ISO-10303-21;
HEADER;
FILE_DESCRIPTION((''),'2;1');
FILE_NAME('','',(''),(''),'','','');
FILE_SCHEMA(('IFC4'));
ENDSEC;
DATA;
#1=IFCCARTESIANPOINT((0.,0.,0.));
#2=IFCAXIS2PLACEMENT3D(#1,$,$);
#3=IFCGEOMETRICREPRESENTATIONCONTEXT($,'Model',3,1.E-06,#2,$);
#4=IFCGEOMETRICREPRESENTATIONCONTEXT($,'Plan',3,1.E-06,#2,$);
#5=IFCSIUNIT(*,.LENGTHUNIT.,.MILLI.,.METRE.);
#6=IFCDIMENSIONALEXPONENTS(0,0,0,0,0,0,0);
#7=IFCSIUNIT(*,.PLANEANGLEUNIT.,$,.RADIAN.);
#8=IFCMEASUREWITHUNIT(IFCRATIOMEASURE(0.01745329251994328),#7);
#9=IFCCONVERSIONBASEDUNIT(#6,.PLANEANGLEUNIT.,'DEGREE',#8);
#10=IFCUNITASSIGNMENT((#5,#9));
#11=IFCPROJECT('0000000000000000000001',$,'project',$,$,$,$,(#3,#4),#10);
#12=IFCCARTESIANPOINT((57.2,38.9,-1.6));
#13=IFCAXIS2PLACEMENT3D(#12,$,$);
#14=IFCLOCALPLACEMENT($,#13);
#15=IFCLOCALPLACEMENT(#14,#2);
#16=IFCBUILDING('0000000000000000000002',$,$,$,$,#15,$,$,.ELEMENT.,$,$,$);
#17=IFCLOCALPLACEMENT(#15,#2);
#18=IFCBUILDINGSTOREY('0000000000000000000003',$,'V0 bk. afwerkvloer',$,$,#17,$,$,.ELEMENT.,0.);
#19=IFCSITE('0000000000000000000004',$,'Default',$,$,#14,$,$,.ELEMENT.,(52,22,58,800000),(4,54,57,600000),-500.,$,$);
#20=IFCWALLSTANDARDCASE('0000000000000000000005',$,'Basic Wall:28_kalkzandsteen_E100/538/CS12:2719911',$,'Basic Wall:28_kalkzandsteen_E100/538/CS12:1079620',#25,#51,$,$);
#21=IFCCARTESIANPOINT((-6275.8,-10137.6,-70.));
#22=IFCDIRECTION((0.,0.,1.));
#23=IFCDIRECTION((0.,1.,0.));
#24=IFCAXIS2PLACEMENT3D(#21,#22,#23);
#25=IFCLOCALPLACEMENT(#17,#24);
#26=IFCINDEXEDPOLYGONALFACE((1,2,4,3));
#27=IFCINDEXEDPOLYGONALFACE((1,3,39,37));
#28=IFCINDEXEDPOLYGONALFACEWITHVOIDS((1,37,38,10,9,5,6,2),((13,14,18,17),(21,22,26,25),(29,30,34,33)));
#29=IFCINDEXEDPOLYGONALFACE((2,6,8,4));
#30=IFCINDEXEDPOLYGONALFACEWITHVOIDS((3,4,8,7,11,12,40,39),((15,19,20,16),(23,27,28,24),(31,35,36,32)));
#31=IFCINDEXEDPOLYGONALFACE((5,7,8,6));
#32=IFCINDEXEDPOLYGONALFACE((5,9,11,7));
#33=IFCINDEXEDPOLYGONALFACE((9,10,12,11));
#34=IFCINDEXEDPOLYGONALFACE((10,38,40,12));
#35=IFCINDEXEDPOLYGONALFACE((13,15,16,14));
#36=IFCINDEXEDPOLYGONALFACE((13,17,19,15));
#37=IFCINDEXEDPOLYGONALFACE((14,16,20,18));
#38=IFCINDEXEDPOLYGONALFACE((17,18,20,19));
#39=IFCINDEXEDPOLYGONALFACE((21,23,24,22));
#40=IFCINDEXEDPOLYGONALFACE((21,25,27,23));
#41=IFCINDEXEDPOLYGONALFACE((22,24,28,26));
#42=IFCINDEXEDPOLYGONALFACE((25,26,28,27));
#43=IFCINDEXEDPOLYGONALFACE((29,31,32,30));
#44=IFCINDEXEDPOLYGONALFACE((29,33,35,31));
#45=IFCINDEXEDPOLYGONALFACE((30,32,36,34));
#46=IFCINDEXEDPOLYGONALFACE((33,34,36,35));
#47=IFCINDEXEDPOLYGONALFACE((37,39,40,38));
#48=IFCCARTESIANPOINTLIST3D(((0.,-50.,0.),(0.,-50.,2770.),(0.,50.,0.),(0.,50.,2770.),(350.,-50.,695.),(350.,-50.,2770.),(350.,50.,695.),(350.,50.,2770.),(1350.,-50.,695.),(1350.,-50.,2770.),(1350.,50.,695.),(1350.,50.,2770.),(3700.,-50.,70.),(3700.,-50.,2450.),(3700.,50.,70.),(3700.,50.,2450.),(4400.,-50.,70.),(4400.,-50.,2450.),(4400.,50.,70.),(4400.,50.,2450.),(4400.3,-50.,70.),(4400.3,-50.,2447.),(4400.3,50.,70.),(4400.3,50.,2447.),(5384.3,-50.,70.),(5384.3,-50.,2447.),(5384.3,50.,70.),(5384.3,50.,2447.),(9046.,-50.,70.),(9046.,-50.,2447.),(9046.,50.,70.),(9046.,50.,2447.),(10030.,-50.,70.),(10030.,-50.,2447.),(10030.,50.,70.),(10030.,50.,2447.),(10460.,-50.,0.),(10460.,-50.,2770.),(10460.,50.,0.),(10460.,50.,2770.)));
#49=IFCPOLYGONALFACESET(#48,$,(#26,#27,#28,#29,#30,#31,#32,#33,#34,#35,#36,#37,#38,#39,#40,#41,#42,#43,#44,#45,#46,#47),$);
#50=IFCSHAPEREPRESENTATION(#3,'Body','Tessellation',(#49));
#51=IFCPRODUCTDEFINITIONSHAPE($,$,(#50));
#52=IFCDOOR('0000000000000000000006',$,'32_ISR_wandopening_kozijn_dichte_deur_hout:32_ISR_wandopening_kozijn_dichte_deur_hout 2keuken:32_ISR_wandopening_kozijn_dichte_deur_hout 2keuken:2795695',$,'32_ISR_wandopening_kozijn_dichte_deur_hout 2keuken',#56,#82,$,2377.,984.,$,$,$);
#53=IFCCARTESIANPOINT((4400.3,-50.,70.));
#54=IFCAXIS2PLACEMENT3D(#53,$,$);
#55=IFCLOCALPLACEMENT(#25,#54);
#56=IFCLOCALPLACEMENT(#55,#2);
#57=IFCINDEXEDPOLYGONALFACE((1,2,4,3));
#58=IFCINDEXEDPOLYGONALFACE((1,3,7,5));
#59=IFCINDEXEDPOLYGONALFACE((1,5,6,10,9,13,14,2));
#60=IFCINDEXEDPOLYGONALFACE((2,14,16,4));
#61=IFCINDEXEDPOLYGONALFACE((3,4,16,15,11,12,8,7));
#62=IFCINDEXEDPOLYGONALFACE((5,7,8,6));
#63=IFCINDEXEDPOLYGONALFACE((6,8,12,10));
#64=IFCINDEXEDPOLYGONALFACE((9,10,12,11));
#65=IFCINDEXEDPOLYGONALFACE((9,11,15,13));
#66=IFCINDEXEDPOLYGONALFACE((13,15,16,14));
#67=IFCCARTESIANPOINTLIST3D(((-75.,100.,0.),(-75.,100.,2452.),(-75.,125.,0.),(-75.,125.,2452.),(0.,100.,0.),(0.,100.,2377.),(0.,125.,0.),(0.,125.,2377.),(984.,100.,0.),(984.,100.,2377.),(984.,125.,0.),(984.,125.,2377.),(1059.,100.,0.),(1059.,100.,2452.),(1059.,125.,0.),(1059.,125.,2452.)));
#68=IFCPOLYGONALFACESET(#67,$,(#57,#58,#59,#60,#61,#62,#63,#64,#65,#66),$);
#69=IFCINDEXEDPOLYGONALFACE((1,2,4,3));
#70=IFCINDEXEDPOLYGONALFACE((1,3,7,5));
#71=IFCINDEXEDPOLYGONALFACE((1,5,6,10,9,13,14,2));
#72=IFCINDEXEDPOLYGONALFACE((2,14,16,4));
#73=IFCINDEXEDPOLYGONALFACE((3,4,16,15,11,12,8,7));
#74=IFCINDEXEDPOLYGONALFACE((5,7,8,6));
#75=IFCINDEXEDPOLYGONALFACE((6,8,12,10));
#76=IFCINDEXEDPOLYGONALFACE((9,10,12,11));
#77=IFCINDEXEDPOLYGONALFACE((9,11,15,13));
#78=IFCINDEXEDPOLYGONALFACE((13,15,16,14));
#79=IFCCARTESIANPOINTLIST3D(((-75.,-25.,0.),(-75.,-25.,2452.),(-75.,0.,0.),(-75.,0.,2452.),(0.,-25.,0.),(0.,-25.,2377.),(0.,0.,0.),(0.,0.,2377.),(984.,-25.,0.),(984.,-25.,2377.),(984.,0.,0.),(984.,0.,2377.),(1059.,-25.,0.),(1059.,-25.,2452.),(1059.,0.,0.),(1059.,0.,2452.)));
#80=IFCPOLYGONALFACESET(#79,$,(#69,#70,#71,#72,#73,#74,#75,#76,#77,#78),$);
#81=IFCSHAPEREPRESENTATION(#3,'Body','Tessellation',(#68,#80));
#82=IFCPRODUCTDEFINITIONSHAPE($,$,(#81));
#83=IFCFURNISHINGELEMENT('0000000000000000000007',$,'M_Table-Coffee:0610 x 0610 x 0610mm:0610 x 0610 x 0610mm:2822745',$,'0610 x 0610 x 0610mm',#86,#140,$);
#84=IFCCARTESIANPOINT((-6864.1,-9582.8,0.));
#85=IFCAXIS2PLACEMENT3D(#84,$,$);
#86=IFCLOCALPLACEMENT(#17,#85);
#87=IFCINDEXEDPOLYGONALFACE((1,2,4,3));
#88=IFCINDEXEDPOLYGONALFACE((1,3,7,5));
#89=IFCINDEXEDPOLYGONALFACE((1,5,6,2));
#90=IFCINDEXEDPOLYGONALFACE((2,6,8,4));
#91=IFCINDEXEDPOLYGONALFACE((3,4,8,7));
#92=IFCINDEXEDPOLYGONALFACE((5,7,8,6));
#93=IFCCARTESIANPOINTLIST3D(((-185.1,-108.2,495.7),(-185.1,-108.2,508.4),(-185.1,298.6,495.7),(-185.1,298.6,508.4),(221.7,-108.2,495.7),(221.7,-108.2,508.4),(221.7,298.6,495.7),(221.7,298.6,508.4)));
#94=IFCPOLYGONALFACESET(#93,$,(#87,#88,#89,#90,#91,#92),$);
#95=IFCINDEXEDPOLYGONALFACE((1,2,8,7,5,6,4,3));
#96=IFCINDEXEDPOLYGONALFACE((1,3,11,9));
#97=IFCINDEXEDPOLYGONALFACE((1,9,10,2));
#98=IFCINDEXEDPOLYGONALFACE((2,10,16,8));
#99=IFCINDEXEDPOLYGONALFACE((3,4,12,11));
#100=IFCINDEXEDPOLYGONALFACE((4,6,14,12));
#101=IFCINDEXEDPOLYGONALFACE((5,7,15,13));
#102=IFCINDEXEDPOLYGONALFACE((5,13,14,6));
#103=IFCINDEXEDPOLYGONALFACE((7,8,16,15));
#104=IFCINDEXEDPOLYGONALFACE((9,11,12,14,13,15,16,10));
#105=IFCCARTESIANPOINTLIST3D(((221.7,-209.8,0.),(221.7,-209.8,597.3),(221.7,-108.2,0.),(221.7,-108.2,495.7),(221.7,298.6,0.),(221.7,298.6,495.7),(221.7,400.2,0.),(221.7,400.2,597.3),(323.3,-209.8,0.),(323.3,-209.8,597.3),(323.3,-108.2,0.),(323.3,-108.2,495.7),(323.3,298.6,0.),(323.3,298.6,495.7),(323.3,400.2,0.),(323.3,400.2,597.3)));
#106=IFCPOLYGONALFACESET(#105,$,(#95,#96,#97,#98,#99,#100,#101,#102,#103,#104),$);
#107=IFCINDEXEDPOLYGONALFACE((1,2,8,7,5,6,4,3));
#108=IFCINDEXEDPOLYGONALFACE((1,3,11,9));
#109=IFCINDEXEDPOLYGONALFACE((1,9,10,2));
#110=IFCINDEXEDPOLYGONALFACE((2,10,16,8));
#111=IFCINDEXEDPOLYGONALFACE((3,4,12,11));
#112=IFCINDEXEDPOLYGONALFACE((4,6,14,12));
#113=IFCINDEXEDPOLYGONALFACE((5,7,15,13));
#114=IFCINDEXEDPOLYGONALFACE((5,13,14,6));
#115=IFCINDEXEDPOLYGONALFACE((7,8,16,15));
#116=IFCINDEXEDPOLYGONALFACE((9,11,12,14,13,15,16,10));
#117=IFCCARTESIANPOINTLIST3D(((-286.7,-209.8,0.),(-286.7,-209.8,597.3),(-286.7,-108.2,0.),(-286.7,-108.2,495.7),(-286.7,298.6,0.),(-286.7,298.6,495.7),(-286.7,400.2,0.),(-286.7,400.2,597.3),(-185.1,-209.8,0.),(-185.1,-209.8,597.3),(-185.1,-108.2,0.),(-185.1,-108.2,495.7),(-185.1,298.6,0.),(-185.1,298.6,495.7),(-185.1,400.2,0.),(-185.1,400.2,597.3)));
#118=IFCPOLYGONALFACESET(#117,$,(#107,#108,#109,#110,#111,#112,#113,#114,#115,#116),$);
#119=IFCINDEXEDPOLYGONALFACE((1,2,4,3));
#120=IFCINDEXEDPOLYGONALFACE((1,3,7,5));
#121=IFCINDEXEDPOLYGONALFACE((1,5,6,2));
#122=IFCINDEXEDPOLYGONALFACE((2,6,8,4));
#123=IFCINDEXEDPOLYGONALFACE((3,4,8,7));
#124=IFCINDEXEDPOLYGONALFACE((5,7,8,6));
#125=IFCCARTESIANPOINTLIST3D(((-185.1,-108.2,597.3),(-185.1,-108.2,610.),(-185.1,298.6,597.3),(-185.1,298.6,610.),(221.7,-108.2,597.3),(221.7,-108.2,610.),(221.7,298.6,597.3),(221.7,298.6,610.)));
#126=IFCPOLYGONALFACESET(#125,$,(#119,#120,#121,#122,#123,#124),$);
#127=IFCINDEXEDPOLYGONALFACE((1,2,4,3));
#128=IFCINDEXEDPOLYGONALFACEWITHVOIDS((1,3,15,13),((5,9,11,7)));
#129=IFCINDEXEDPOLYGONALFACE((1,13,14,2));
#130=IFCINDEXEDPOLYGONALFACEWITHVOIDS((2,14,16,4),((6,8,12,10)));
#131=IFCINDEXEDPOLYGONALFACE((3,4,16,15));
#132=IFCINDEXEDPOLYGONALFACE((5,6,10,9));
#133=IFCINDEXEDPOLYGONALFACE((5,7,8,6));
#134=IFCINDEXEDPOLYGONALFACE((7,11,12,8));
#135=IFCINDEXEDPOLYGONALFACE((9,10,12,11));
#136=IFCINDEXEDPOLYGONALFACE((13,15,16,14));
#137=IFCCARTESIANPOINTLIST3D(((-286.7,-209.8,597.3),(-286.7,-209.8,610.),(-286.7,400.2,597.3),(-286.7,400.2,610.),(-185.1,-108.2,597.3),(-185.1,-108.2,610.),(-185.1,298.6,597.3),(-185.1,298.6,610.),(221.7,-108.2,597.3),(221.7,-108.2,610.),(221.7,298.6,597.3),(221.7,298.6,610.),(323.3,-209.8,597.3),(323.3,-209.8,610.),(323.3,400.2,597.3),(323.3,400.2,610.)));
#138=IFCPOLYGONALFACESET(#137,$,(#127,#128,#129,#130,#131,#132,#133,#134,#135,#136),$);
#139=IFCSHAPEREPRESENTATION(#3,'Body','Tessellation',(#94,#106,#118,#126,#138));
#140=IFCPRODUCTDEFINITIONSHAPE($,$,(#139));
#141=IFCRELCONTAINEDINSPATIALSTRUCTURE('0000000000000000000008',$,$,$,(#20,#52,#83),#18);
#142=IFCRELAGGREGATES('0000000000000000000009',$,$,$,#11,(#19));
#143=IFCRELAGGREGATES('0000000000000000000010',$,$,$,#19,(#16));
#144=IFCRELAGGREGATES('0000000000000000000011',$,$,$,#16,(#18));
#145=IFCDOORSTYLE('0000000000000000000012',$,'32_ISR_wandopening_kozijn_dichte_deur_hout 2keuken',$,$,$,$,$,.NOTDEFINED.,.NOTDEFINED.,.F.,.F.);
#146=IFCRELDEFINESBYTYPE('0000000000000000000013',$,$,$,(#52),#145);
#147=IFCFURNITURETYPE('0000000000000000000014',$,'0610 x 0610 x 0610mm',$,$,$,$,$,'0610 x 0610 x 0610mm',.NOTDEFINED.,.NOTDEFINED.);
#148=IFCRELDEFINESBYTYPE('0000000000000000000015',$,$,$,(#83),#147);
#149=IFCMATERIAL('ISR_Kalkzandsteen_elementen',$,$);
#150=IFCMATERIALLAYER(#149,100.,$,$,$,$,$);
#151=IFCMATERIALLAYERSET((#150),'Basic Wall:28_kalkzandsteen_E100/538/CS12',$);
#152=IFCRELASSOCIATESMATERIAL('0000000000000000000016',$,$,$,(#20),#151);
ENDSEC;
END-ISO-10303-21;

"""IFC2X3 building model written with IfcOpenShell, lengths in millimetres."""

from ifc_helpers import new_model, entity, si_unit, converted_unit, frame, frame_2d, origin, origin_2d_with_axis, place, context, project, spatial, polyline, rectangle, outline, extrude, source, transform, mapped, material, layer, layer_set, layer_usage, type_object, type_shapes, element, fill, save


model = new_model("IFC2X3")

# Units and contexts
model_context = context("Model", 3, precision=1e-06, world=origin())
plan_context = context("Plan", 3, precision=1e-06, world=origin())
ifc_project = project(units=[si_unit("LENGTHUNIT", "METRE", prefix="MILLI"), converted_unit("PLANEANGLEUNIT", "DEGREE", entity("IfcRatioMeasure", 0.01745329251994328), si_unit("PLANEANGLEUNIT", "RADIAN"), dimensions=[0, 0, 0, 0, 0, 0, 0])], contexts=[model_context, plan_context])

# Site, building, storey
site_placement = place(None, frame((57.2, 38.9, -1.6)))
site = spatial("IfcSite", under=ifc_project, at=site_placement, Name="Default", CompositionType="ELEMENT", RefLatitude=(52, 22, 58, 800000), RefLongitude=(4, 54, 57, 600000), RefElevation=-500.0)
building_placement = place(site_placement, origin())
building = spatial("IfcBuilding", under=site, at=building_placement, CompositionType="ELEMENT")
storey_placement = place(building_placement, origin())
storey = spatial("IfcBuildingStorey", under=building, at=storey_placement, Name="V0 bk. afwerkvloer", CompositionType="ELEMENT", Elevation=0.0)

# Wall, openings, door
ifc_material_1 = material(Name="ISR_Kalkzandsteen_elementen")
ifc_layer_1 = layer(ifc_material_1, 100.0)
ifc_layer_set_1 = layer_set([ifc_layer_1], Name="Basic Wall:28_kalkzandsteen_E100/538/CS12")
ifc_layer_usage_1 = layer_usage(ifc_layer_set_1, "AXIS2", "NEGATIVE", 50.0)
wall_1_placement = place(storey_placement, frame((-6275.8, -10137.6, -70.0), z_axis=(0.0, 0.0, 1.0), x_axis=(0.0, 1.0, 0.0)))
wall_1 = element("IfcWallStandardCase", 1, at=wall_1_placement, inside=storey, material=ifc_layer_usage_1, Name="Basic Wall:28_kalkzandsteen_E100/538/CS12:2719911", ObjectType="Basic Wall:28_kalkzandsteen_E100/538/CS12:1079620", context=model_context, shape_type="SweptSolid", body=[
    extrude(rectangle(XDim=10460.0, YDim=100.0, at=frame_2d((5230.0, 0.0), x_axis=(-1.0, 0.0))), origin(), (0.0, 0.0, 1.0), 2770.0),
])
opening_1_placement = place(wall_1_placement, origin())
element("IfcOpeningElement", 2, at=opening_1_placement, cuts=wall_1, ObjectType="Opening", context=model_context, shape_type="SweptSolid", body=[
    extrude(rectangle(XDim=2075.0, YDim=1000.0, at=frame_2d((0.0, 0.0), x_axis=(0.0, 1.0))), frame((850.0, -202.4, 1732.5), z_axis=(0.0, 1.0, 0.0), x_axis=(-1.0, 0.0, 0.0)), (0.0, 0.0, 1.0), 404.8),
])
opening_2_placement = place(wall_1_placement, origin())
element("IfcOpeningElement", 3, at=opening_2_placement, cuts=wall_1, ObjectType="Opening", context=model_context, shape_type="SweptSolid", body=[
    extrude(rectangle(XDim=2380.0, YDim=700.0, at=origin_2d_with_axis()), frame((4050.0, -202.4, 1260.0), z_axis=(0.0, 1.0, 0.0), x_axis=(0.0, 0.0, 1.0)), (0.0, 0.0, 1.0), 404.8),
])
opening_3_placement = place(wall_1_placement, origin())
element("IfcOpeningElement", 4, at=opening_3_placement, cuts=wall_1, ObjectType="Opening", context=model_context, shape_type="SweptSolid", body=[
    extrude(rectangle(XDim=2377.0, YDim=984.0, at=frame_2d((0.0, 0.0), x_axis=(0.0, 1.0))), frame((9538.0, -1574.0, 1258.5), z_axis=(0.0, 1.0, 0.0), x_axis=(-1.0, 0.0, 0.0)), (0.0, 0.0, 1.0), 3048.0),
])
opening_4_placement = place(wall_1_placement, frame((4400.3, -50.0, 70.0)))
opening_4 = element("IfcOpeningElement", 5, at=opening_4_placement, cuts=wall_1, ObjectType="Opening", context=model_context, shape_type="SweptSolid", body=[
    extrude(rectangle(XDim=2377.0, YDim=984.0, at=frame_2d((1188.5, 492.0), x_axis=(1.0, 0.0))), frame((0.0, 0.0, 0.0), z_axis=(0.0, 1.0, 0.0), x_axis=(0.0, 0.0, 1.0)), (0.0, 0.0, 1.0), 100.0),
])
door_style_1 = type_object("IfcDoorStyle", Name="32_ISR_wandopening_kozijn_dichte_deur_hout 2keuken", ConstructionType="NOTDEFINED", OperationType="NOTDEFINED", ParameterTakesPrecedence=False, Sizeable=False)
shared_shape_1 = source(origin(), model_context, "Body", "SweptSolid", [
    extrude(outline(polyline([(-1169.7, 492.0), (1207.2, 492.0), (1207.2, 567.0), (-1244.7, 567.0), (-1244.7, -567.0), (1207.2, -567.0), (1207.2, -492.0), (-1169.7, -492.0), (-1169.7, 492.0)])), frame((492.0, 100.0, 1207.2), z_axis=(0.0, 1.0, 0.0), x_axis=(0.0, 0.0, -1.0)), (0.0, 0.0, 1.0), 25.0),
    extrude(outline(polyline([(-567.0, -1244.7), (567.0, -1244.7), (567.0, 1207.2), (492.0, 1207.2), (492.0, -1169.7), (-492.0, -1169.7), (-492.0, 1207.2), (-567.0, 1207.2), (-567.0, -1244.7)])), frame((492.0, -25.0, 1207.2), z_axis=(0.0, 1.0, 0.0), x_axis=(1.0, 0.0, 0.0)), (0.0, 0.0, 1.0), 25.0),
])
type_shapes(door_style_1, [shared_shape_1])
door_1_placement = place(opening_4_placement, origin())
door_1 = element("IfcDoor", 6, at=door_1_placement, inside=storey, type_object=door_style_1, Name="32_ISR_wandopening_kozijn_dichte_deur_hout:32_ISR_wandopening_kozijn_dichte_deur_hout 2keuken:32_ISR_wandopening_kozijn_dichte_deur_hout 2keuken:2795695", ObjectType="32_ISR_wandopening_kozijn_dichte_deur_hout 2keuken", OverallHeight=2377.0, OverallWidth=984.0, context=model_context, shape_type="MappedRepresentation", body=[
    mapped(shared_shape_1, transform((0.0, 0.0, 0.0), scale=1.0)),
])
fill(opening_4, door_1)

# Furnishing element
furniture_type = type_object("IfcFurnitureType", Name="0610 x 0610 x 0610mm", ElementType="0610 x 0610 x 0610mm", AssemblyPlace="NOTDEFINED")
shared_shape_2 = source(origin(), model_context, "Body", "SweptSolid", [
    extrude(rectangle(XDim=406.8, YDim=406.8, at=origin_2d_with_axis()), frame((18.3, 95.2, 495.7), z_axis=(0.0, 0.0, 1.0), x_axis=(-1.0, 0.0, 0.0)), (0.0, 0.0, 1.0), 12.7),
    extrude(outline(polyline([(-273.2, -305.0), (324.0, -305.0), (324.0, 305.0), (-273.2, 305.0), (-273.2, 203.4), (222.5, 203.4), (222.5, -203.4), (-273.2, -203.4), (-273.2, -305.0)])), frame((221.7, 95.2, 273.2), z_axis=(1.0, 0.0, 0.0), x_axis=(0.0, 0.0, 1.0)), (0.0, 0.0, 1.0), 101.6),
    extrude(outline(polyline([(-305.0, -324.1), (305.0, -324.1), (305.0, 273.3), (203.4, 273.3), (203.4, -222.4), (-203.4, -222.4), (-203.4, 273.3), (-305.0, 273.3), (-305.0, -324.1)])), frame((-286.7, 95.2, 273.3), z_axis=(1.0, 0.0, 0.0), x_axis=(0.0, -1.0, 0.0)), (0.0, 0.0, 1.0), 101.6),
    extrude(rectangle(XDim=406.8, YDim=406.8, at=origin_2d_with_axis()), frame((18.3, 95.2, 597.3), z_axis=(0.0, 0.0, 1.0), x_axis=(-1.0, 0.0, 0.0)), (0.0, 0.0, 1.0), 12.7),
    extrude(outline(polyline([(-305.0, -305.0), (305.0, -305.0), (305.0, 305.0), (-305.0, 305.0), (-305.0, -305.0)]), holes=[polyline([(-203.4, -203.4), (-203.4, 203.4), (203.4, 203.4), (203.4, -203.4), (-203.4, -203.4)])]), frame((18.3, 95.2, 597.3), z_axis=(0.0, 0.0, 1.0), x_axis=(-1.0, 0.0, 0.0)), (0.0, 0.0, 1.0), 12.7),
])
type_shapes(furniture_type, [shared_shape_2])
furnishing_placement = place(storey_placement, frame((-6864.1, -9582.8, 0.0)))
element("IfcFurnishingElement", 7, at=furnishing_placement, inside=storey, type_object=furniture_type, Name="M_Table-Coffee:0610 x 0610 x 0610mm:0610 x 0610 x 0610mm:2822745", ObjectType="0610 x 0610 x 0610mm", context=model_context, shape_type="MappedRepresentation", body=[
    mapped(shared_shape_2, transform((0.0, 0.0, 0.0), scale=1.0)),
])

save(model, "model.ifc")
